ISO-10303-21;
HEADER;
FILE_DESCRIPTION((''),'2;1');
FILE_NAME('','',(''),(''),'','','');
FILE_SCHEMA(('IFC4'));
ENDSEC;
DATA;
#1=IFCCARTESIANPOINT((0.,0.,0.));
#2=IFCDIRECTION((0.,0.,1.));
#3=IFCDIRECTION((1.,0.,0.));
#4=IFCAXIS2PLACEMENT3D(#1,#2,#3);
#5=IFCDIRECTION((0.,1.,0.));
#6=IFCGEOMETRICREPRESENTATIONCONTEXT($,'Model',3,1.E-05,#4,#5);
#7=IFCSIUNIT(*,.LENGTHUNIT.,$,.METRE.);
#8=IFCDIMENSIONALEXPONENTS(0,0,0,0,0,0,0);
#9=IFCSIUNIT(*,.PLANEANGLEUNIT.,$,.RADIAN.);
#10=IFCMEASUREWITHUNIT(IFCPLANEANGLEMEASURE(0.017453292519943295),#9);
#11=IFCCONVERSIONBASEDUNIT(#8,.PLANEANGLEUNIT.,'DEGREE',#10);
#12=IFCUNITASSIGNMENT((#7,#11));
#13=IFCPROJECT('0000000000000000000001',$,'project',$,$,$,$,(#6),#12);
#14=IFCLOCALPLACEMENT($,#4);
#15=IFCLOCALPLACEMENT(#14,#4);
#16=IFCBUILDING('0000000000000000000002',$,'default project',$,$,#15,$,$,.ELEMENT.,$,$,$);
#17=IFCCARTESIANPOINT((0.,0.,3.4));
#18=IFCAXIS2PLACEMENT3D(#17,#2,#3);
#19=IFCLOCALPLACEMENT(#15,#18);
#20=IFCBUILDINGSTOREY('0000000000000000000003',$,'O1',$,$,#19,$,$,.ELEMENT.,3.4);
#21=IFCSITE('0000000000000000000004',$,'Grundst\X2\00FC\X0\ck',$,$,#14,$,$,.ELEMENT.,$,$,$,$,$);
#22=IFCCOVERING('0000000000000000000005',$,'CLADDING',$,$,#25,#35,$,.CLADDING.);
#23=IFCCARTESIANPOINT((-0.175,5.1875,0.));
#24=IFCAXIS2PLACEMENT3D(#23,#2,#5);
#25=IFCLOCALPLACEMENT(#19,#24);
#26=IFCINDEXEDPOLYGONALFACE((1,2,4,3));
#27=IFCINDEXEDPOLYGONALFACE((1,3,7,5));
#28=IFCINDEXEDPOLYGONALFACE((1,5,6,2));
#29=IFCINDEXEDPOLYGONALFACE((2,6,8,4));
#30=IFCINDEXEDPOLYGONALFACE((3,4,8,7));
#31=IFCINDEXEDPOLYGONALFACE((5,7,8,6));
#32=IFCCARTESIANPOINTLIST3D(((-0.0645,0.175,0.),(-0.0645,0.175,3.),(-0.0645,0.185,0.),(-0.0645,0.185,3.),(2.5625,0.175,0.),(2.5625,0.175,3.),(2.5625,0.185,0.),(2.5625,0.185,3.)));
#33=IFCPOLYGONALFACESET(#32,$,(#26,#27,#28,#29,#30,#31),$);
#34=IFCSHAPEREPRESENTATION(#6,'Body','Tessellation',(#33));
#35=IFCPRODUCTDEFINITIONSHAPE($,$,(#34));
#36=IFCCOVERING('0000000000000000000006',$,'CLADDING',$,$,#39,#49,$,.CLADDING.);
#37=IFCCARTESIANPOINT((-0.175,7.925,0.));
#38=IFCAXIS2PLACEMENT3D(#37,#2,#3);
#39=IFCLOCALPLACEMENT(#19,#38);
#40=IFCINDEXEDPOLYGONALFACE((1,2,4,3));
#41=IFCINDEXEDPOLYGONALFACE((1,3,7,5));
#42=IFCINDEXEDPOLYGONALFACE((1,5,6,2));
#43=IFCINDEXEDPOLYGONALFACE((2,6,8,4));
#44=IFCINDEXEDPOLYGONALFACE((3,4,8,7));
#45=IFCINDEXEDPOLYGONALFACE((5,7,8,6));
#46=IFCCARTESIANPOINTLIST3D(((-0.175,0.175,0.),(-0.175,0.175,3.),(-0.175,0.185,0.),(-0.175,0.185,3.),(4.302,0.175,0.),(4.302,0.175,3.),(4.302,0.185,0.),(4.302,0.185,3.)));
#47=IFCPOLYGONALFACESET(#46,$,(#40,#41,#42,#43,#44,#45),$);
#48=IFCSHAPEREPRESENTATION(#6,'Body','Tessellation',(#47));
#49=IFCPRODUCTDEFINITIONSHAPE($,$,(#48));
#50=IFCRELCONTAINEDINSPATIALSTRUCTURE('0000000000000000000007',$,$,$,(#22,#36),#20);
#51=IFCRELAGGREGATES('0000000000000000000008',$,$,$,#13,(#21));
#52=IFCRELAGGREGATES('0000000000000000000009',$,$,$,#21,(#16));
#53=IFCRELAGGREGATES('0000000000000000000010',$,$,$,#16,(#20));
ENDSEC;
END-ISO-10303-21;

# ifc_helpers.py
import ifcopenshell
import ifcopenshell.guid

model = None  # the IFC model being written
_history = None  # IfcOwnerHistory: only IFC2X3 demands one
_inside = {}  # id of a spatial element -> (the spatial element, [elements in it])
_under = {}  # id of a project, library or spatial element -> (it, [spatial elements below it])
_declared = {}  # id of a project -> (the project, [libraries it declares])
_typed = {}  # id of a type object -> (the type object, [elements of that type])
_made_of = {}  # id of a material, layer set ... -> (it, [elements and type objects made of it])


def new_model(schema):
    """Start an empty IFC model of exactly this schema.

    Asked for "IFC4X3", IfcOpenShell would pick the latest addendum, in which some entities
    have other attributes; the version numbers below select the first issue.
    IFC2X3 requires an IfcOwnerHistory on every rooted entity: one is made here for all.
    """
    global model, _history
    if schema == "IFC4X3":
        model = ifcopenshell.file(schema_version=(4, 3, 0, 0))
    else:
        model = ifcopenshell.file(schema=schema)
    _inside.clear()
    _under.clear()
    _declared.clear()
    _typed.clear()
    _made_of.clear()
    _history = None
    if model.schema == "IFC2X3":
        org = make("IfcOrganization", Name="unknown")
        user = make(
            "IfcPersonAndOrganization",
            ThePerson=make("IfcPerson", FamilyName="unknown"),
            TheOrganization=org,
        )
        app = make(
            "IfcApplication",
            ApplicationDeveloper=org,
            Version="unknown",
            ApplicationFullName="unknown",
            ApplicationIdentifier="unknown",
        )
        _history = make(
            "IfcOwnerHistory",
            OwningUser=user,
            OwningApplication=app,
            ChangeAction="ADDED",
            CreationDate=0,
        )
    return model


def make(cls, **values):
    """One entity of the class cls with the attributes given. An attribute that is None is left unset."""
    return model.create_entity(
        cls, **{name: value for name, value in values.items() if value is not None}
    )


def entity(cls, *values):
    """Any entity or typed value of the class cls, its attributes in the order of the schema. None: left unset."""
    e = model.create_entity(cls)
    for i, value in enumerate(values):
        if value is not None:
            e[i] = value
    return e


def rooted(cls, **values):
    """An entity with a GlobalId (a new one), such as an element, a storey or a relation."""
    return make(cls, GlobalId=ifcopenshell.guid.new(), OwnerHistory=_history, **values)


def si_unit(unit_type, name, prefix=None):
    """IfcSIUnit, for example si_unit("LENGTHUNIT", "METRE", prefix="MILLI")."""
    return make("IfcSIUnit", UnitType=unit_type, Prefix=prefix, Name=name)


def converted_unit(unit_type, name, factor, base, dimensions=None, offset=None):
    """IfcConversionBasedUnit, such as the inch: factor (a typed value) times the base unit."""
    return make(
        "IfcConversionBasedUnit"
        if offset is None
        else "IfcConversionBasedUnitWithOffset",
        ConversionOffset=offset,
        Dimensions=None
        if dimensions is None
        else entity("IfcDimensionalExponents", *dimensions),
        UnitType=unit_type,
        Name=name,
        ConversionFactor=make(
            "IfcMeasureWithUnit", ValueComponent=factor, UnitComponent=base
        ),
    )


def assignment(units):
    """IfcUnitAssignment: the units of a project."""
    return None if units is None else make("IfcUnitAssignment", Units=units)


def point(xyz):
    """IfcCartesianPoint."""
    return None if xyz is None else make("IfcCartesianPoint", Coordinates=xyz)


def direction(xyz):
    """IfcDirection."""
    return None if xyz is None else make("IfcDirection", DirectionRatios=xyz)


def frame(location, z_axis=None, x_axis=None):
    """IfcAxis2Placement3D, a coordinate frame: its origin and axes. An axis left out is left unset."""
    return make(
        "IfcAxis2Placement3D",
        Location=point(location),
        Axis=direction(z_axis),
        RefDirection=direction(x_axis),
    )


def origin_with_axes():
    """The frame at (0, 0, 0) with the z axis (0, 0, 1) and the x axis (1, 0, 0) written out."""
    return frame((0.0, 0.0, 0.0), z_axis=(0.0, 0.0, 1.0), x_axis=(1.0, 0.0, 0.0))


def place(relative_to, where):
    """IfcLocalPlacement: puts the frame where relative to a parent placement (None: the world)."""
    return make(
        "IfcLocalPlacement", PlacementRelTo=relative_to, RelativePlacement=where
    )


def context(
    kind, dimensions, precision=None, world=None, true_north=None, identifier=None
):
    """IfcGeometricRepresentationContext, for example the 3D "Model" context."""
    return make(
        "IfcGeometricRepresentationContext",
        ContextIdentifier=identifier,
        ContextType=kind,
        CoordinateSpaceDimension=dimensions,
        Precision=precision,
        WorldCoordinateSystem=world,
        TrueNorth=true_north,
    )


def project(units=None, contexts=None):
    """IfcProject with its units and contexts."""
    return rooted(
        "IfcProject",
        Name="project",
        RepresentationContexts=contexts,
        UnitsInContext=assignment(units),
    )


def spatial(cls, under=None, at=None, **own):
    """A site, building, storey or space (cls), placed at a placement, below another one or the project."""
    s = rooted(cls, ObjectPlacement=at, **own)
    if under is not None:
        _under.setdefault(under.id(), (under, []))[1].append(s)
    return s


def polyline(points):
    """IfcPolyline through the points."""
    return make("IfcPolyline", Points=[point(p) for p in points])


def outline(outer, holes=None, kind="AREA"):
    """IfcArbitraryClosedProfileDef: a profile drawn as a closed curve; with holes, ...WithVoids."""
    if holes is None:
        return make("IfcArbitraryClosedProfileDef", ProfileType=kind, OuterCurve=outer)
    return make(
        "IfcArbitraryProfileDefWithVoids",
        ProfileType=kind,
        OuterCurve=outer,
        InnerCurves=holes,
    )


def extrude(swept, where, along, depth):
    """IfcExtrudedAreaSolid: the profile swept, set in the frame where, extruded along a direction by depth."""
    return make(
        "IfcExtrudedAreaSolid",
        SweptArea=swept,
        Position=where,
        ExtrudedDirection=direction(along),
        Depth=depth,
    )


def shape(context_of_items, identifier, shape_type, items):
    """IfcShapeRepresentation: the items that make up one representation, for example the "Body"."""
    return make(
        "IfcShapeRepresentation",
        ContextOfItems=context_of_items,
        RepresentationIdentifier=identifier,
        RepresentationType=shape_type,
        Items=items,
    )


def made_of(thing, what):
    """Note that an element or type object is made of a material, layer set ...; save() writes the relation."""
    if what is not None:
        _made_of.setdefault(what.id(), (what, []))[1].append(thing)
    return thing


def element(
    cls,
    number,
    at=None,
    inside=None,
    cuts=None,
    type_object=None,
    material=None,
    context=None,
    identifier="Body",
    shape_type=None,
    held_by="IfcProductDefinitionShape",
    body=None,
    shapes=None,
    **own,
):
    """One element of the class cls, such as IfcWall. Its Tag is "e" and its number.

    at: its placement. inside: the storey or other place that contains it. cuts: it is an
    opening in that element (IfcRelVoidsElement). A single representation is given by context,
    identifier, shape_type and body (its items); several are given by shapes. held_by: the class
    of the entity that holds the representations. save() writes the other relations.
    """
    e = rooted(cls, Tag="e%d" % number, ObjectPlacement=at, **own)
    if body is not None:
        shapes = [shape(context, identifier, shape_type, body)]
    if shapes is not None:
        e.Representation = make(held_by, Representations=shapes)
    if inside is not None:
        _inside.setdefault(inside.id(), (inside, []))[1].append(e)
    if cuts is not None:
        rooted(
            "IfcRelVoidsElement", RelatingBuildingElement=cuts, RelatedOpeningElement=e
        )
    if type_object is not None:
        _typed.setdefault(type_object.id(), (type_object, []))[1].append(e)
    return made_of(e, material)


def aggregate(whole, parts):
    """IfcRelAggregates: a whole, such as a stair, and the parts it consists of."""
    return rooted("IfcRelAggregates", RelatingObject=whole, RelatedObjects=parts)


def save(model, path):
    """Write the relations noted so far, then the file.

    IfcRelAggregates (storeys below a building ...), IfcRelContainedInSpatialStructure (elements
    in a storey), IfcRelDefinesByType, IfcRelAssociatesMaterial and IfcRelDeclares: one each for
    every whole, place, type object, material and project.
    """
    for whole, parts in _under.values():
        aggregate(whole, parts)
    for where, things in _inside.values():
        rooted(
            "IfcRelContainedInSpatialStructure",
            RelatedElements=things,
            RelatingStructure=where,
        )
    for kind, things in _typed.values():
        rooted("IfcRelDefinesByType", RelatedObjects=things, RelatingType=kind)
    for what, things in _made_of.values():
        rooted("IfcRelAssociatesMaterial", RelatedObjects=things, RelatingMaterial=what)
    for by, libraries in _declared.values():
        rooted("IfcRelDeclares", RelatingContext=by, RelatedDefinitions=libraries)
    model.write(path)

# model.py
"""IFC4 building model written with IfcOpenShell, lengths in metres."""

from ifc_helpers import new_model, entity, si_unit, converted_unit, direction, frame, origin_with_axes, place, context, project, spatial, polyline, outline, extrude, element, save


model = new_model("IFC4")

# Units and contexts
model_context = context("Model", 3, precision=1e-05, world=origin_with_axes(), true_north=direction((0.0, 1.0, 0.0)))
ifc_project = project(units=[si_unit("LENGTHUNIT", "METRE"), converted_unit("PLANEANGLEUNIT", "DEGREE", entity("IfcPlaneAngleMeasure", 0.017453292519943295), si_unit("PLANEANGLEUNIT", "RADIAN"), dimensions=[0, 0, 0, 0, 0, 0, 0])], contexts=[model_context])

# Site, building, storey
site_placement = place(None, origin_with_axes())
site = spatial("IfcSite", under=ifc_project, at=site_placement, Name="Grundstück", CompositionType="ELEMENT")
building_placement = place(site_placement, origin_with_axes())
building = spatial("IfcBuilding", under=site, at=building_placement, Name="default project", CompositionType="ELEMENT")
placement_1 = place(building_placement, frame((0.0, 0.0, 3.4), z_axis=(0.0, 0.0, 1.0), x_axis=(1.0, 0.0, 0.0)))
storey = spatial("IfcBuildingStorey", under=building, at=placement_1, Name="O1", CompositionType="ELEMENT", Elevation=3.4)

# Shared definitions
placement_2 = place(placement_1, frame((-0.175, 5.1875, 0.0), z_axis=(0.0, 0.0, 1.0), x_axis=(0.0, 1.0, 0.0)))
placement_3 = place(placement_1, frame((-0.175, 7.925, 0.0), z_axis=(0.0, 0.0, 1.0), x_axis=(1.0, 0.0, 0.0)))

# Coverings
element("IfcCovering", 1, at=placement_2, inside=storey, Name="CLADDING", PredefinedType="CLADDING", context=model_context, shape_type="SweptSolid", body=[
    extrude(outline(polyline([(2.5625, 0.185), (-0.0645, 0.185), (-0.0645, 0.175), (2.5625, 0.175), (2.5625, 0.185)])), origin_with_axes(), (0.0, 0.0, 1.0), 3.0),
])
element("IfcCovering", 2, at=placement_3, inside=storey, Name="CLADDING", PredefinedType="CLADDING", context=model_context, shape_type="SweptSolid", body=[
    extrude(outline(polyline([(4.302, 0.185), (-0.175, 0.185), (-0.175, 0.175), (4.302, 0.175), (4.302, 0.185)])), origin_with_axes(), (0.0, 0.0, 1.0), 3.0),
])

save(model, "model.ifc")
